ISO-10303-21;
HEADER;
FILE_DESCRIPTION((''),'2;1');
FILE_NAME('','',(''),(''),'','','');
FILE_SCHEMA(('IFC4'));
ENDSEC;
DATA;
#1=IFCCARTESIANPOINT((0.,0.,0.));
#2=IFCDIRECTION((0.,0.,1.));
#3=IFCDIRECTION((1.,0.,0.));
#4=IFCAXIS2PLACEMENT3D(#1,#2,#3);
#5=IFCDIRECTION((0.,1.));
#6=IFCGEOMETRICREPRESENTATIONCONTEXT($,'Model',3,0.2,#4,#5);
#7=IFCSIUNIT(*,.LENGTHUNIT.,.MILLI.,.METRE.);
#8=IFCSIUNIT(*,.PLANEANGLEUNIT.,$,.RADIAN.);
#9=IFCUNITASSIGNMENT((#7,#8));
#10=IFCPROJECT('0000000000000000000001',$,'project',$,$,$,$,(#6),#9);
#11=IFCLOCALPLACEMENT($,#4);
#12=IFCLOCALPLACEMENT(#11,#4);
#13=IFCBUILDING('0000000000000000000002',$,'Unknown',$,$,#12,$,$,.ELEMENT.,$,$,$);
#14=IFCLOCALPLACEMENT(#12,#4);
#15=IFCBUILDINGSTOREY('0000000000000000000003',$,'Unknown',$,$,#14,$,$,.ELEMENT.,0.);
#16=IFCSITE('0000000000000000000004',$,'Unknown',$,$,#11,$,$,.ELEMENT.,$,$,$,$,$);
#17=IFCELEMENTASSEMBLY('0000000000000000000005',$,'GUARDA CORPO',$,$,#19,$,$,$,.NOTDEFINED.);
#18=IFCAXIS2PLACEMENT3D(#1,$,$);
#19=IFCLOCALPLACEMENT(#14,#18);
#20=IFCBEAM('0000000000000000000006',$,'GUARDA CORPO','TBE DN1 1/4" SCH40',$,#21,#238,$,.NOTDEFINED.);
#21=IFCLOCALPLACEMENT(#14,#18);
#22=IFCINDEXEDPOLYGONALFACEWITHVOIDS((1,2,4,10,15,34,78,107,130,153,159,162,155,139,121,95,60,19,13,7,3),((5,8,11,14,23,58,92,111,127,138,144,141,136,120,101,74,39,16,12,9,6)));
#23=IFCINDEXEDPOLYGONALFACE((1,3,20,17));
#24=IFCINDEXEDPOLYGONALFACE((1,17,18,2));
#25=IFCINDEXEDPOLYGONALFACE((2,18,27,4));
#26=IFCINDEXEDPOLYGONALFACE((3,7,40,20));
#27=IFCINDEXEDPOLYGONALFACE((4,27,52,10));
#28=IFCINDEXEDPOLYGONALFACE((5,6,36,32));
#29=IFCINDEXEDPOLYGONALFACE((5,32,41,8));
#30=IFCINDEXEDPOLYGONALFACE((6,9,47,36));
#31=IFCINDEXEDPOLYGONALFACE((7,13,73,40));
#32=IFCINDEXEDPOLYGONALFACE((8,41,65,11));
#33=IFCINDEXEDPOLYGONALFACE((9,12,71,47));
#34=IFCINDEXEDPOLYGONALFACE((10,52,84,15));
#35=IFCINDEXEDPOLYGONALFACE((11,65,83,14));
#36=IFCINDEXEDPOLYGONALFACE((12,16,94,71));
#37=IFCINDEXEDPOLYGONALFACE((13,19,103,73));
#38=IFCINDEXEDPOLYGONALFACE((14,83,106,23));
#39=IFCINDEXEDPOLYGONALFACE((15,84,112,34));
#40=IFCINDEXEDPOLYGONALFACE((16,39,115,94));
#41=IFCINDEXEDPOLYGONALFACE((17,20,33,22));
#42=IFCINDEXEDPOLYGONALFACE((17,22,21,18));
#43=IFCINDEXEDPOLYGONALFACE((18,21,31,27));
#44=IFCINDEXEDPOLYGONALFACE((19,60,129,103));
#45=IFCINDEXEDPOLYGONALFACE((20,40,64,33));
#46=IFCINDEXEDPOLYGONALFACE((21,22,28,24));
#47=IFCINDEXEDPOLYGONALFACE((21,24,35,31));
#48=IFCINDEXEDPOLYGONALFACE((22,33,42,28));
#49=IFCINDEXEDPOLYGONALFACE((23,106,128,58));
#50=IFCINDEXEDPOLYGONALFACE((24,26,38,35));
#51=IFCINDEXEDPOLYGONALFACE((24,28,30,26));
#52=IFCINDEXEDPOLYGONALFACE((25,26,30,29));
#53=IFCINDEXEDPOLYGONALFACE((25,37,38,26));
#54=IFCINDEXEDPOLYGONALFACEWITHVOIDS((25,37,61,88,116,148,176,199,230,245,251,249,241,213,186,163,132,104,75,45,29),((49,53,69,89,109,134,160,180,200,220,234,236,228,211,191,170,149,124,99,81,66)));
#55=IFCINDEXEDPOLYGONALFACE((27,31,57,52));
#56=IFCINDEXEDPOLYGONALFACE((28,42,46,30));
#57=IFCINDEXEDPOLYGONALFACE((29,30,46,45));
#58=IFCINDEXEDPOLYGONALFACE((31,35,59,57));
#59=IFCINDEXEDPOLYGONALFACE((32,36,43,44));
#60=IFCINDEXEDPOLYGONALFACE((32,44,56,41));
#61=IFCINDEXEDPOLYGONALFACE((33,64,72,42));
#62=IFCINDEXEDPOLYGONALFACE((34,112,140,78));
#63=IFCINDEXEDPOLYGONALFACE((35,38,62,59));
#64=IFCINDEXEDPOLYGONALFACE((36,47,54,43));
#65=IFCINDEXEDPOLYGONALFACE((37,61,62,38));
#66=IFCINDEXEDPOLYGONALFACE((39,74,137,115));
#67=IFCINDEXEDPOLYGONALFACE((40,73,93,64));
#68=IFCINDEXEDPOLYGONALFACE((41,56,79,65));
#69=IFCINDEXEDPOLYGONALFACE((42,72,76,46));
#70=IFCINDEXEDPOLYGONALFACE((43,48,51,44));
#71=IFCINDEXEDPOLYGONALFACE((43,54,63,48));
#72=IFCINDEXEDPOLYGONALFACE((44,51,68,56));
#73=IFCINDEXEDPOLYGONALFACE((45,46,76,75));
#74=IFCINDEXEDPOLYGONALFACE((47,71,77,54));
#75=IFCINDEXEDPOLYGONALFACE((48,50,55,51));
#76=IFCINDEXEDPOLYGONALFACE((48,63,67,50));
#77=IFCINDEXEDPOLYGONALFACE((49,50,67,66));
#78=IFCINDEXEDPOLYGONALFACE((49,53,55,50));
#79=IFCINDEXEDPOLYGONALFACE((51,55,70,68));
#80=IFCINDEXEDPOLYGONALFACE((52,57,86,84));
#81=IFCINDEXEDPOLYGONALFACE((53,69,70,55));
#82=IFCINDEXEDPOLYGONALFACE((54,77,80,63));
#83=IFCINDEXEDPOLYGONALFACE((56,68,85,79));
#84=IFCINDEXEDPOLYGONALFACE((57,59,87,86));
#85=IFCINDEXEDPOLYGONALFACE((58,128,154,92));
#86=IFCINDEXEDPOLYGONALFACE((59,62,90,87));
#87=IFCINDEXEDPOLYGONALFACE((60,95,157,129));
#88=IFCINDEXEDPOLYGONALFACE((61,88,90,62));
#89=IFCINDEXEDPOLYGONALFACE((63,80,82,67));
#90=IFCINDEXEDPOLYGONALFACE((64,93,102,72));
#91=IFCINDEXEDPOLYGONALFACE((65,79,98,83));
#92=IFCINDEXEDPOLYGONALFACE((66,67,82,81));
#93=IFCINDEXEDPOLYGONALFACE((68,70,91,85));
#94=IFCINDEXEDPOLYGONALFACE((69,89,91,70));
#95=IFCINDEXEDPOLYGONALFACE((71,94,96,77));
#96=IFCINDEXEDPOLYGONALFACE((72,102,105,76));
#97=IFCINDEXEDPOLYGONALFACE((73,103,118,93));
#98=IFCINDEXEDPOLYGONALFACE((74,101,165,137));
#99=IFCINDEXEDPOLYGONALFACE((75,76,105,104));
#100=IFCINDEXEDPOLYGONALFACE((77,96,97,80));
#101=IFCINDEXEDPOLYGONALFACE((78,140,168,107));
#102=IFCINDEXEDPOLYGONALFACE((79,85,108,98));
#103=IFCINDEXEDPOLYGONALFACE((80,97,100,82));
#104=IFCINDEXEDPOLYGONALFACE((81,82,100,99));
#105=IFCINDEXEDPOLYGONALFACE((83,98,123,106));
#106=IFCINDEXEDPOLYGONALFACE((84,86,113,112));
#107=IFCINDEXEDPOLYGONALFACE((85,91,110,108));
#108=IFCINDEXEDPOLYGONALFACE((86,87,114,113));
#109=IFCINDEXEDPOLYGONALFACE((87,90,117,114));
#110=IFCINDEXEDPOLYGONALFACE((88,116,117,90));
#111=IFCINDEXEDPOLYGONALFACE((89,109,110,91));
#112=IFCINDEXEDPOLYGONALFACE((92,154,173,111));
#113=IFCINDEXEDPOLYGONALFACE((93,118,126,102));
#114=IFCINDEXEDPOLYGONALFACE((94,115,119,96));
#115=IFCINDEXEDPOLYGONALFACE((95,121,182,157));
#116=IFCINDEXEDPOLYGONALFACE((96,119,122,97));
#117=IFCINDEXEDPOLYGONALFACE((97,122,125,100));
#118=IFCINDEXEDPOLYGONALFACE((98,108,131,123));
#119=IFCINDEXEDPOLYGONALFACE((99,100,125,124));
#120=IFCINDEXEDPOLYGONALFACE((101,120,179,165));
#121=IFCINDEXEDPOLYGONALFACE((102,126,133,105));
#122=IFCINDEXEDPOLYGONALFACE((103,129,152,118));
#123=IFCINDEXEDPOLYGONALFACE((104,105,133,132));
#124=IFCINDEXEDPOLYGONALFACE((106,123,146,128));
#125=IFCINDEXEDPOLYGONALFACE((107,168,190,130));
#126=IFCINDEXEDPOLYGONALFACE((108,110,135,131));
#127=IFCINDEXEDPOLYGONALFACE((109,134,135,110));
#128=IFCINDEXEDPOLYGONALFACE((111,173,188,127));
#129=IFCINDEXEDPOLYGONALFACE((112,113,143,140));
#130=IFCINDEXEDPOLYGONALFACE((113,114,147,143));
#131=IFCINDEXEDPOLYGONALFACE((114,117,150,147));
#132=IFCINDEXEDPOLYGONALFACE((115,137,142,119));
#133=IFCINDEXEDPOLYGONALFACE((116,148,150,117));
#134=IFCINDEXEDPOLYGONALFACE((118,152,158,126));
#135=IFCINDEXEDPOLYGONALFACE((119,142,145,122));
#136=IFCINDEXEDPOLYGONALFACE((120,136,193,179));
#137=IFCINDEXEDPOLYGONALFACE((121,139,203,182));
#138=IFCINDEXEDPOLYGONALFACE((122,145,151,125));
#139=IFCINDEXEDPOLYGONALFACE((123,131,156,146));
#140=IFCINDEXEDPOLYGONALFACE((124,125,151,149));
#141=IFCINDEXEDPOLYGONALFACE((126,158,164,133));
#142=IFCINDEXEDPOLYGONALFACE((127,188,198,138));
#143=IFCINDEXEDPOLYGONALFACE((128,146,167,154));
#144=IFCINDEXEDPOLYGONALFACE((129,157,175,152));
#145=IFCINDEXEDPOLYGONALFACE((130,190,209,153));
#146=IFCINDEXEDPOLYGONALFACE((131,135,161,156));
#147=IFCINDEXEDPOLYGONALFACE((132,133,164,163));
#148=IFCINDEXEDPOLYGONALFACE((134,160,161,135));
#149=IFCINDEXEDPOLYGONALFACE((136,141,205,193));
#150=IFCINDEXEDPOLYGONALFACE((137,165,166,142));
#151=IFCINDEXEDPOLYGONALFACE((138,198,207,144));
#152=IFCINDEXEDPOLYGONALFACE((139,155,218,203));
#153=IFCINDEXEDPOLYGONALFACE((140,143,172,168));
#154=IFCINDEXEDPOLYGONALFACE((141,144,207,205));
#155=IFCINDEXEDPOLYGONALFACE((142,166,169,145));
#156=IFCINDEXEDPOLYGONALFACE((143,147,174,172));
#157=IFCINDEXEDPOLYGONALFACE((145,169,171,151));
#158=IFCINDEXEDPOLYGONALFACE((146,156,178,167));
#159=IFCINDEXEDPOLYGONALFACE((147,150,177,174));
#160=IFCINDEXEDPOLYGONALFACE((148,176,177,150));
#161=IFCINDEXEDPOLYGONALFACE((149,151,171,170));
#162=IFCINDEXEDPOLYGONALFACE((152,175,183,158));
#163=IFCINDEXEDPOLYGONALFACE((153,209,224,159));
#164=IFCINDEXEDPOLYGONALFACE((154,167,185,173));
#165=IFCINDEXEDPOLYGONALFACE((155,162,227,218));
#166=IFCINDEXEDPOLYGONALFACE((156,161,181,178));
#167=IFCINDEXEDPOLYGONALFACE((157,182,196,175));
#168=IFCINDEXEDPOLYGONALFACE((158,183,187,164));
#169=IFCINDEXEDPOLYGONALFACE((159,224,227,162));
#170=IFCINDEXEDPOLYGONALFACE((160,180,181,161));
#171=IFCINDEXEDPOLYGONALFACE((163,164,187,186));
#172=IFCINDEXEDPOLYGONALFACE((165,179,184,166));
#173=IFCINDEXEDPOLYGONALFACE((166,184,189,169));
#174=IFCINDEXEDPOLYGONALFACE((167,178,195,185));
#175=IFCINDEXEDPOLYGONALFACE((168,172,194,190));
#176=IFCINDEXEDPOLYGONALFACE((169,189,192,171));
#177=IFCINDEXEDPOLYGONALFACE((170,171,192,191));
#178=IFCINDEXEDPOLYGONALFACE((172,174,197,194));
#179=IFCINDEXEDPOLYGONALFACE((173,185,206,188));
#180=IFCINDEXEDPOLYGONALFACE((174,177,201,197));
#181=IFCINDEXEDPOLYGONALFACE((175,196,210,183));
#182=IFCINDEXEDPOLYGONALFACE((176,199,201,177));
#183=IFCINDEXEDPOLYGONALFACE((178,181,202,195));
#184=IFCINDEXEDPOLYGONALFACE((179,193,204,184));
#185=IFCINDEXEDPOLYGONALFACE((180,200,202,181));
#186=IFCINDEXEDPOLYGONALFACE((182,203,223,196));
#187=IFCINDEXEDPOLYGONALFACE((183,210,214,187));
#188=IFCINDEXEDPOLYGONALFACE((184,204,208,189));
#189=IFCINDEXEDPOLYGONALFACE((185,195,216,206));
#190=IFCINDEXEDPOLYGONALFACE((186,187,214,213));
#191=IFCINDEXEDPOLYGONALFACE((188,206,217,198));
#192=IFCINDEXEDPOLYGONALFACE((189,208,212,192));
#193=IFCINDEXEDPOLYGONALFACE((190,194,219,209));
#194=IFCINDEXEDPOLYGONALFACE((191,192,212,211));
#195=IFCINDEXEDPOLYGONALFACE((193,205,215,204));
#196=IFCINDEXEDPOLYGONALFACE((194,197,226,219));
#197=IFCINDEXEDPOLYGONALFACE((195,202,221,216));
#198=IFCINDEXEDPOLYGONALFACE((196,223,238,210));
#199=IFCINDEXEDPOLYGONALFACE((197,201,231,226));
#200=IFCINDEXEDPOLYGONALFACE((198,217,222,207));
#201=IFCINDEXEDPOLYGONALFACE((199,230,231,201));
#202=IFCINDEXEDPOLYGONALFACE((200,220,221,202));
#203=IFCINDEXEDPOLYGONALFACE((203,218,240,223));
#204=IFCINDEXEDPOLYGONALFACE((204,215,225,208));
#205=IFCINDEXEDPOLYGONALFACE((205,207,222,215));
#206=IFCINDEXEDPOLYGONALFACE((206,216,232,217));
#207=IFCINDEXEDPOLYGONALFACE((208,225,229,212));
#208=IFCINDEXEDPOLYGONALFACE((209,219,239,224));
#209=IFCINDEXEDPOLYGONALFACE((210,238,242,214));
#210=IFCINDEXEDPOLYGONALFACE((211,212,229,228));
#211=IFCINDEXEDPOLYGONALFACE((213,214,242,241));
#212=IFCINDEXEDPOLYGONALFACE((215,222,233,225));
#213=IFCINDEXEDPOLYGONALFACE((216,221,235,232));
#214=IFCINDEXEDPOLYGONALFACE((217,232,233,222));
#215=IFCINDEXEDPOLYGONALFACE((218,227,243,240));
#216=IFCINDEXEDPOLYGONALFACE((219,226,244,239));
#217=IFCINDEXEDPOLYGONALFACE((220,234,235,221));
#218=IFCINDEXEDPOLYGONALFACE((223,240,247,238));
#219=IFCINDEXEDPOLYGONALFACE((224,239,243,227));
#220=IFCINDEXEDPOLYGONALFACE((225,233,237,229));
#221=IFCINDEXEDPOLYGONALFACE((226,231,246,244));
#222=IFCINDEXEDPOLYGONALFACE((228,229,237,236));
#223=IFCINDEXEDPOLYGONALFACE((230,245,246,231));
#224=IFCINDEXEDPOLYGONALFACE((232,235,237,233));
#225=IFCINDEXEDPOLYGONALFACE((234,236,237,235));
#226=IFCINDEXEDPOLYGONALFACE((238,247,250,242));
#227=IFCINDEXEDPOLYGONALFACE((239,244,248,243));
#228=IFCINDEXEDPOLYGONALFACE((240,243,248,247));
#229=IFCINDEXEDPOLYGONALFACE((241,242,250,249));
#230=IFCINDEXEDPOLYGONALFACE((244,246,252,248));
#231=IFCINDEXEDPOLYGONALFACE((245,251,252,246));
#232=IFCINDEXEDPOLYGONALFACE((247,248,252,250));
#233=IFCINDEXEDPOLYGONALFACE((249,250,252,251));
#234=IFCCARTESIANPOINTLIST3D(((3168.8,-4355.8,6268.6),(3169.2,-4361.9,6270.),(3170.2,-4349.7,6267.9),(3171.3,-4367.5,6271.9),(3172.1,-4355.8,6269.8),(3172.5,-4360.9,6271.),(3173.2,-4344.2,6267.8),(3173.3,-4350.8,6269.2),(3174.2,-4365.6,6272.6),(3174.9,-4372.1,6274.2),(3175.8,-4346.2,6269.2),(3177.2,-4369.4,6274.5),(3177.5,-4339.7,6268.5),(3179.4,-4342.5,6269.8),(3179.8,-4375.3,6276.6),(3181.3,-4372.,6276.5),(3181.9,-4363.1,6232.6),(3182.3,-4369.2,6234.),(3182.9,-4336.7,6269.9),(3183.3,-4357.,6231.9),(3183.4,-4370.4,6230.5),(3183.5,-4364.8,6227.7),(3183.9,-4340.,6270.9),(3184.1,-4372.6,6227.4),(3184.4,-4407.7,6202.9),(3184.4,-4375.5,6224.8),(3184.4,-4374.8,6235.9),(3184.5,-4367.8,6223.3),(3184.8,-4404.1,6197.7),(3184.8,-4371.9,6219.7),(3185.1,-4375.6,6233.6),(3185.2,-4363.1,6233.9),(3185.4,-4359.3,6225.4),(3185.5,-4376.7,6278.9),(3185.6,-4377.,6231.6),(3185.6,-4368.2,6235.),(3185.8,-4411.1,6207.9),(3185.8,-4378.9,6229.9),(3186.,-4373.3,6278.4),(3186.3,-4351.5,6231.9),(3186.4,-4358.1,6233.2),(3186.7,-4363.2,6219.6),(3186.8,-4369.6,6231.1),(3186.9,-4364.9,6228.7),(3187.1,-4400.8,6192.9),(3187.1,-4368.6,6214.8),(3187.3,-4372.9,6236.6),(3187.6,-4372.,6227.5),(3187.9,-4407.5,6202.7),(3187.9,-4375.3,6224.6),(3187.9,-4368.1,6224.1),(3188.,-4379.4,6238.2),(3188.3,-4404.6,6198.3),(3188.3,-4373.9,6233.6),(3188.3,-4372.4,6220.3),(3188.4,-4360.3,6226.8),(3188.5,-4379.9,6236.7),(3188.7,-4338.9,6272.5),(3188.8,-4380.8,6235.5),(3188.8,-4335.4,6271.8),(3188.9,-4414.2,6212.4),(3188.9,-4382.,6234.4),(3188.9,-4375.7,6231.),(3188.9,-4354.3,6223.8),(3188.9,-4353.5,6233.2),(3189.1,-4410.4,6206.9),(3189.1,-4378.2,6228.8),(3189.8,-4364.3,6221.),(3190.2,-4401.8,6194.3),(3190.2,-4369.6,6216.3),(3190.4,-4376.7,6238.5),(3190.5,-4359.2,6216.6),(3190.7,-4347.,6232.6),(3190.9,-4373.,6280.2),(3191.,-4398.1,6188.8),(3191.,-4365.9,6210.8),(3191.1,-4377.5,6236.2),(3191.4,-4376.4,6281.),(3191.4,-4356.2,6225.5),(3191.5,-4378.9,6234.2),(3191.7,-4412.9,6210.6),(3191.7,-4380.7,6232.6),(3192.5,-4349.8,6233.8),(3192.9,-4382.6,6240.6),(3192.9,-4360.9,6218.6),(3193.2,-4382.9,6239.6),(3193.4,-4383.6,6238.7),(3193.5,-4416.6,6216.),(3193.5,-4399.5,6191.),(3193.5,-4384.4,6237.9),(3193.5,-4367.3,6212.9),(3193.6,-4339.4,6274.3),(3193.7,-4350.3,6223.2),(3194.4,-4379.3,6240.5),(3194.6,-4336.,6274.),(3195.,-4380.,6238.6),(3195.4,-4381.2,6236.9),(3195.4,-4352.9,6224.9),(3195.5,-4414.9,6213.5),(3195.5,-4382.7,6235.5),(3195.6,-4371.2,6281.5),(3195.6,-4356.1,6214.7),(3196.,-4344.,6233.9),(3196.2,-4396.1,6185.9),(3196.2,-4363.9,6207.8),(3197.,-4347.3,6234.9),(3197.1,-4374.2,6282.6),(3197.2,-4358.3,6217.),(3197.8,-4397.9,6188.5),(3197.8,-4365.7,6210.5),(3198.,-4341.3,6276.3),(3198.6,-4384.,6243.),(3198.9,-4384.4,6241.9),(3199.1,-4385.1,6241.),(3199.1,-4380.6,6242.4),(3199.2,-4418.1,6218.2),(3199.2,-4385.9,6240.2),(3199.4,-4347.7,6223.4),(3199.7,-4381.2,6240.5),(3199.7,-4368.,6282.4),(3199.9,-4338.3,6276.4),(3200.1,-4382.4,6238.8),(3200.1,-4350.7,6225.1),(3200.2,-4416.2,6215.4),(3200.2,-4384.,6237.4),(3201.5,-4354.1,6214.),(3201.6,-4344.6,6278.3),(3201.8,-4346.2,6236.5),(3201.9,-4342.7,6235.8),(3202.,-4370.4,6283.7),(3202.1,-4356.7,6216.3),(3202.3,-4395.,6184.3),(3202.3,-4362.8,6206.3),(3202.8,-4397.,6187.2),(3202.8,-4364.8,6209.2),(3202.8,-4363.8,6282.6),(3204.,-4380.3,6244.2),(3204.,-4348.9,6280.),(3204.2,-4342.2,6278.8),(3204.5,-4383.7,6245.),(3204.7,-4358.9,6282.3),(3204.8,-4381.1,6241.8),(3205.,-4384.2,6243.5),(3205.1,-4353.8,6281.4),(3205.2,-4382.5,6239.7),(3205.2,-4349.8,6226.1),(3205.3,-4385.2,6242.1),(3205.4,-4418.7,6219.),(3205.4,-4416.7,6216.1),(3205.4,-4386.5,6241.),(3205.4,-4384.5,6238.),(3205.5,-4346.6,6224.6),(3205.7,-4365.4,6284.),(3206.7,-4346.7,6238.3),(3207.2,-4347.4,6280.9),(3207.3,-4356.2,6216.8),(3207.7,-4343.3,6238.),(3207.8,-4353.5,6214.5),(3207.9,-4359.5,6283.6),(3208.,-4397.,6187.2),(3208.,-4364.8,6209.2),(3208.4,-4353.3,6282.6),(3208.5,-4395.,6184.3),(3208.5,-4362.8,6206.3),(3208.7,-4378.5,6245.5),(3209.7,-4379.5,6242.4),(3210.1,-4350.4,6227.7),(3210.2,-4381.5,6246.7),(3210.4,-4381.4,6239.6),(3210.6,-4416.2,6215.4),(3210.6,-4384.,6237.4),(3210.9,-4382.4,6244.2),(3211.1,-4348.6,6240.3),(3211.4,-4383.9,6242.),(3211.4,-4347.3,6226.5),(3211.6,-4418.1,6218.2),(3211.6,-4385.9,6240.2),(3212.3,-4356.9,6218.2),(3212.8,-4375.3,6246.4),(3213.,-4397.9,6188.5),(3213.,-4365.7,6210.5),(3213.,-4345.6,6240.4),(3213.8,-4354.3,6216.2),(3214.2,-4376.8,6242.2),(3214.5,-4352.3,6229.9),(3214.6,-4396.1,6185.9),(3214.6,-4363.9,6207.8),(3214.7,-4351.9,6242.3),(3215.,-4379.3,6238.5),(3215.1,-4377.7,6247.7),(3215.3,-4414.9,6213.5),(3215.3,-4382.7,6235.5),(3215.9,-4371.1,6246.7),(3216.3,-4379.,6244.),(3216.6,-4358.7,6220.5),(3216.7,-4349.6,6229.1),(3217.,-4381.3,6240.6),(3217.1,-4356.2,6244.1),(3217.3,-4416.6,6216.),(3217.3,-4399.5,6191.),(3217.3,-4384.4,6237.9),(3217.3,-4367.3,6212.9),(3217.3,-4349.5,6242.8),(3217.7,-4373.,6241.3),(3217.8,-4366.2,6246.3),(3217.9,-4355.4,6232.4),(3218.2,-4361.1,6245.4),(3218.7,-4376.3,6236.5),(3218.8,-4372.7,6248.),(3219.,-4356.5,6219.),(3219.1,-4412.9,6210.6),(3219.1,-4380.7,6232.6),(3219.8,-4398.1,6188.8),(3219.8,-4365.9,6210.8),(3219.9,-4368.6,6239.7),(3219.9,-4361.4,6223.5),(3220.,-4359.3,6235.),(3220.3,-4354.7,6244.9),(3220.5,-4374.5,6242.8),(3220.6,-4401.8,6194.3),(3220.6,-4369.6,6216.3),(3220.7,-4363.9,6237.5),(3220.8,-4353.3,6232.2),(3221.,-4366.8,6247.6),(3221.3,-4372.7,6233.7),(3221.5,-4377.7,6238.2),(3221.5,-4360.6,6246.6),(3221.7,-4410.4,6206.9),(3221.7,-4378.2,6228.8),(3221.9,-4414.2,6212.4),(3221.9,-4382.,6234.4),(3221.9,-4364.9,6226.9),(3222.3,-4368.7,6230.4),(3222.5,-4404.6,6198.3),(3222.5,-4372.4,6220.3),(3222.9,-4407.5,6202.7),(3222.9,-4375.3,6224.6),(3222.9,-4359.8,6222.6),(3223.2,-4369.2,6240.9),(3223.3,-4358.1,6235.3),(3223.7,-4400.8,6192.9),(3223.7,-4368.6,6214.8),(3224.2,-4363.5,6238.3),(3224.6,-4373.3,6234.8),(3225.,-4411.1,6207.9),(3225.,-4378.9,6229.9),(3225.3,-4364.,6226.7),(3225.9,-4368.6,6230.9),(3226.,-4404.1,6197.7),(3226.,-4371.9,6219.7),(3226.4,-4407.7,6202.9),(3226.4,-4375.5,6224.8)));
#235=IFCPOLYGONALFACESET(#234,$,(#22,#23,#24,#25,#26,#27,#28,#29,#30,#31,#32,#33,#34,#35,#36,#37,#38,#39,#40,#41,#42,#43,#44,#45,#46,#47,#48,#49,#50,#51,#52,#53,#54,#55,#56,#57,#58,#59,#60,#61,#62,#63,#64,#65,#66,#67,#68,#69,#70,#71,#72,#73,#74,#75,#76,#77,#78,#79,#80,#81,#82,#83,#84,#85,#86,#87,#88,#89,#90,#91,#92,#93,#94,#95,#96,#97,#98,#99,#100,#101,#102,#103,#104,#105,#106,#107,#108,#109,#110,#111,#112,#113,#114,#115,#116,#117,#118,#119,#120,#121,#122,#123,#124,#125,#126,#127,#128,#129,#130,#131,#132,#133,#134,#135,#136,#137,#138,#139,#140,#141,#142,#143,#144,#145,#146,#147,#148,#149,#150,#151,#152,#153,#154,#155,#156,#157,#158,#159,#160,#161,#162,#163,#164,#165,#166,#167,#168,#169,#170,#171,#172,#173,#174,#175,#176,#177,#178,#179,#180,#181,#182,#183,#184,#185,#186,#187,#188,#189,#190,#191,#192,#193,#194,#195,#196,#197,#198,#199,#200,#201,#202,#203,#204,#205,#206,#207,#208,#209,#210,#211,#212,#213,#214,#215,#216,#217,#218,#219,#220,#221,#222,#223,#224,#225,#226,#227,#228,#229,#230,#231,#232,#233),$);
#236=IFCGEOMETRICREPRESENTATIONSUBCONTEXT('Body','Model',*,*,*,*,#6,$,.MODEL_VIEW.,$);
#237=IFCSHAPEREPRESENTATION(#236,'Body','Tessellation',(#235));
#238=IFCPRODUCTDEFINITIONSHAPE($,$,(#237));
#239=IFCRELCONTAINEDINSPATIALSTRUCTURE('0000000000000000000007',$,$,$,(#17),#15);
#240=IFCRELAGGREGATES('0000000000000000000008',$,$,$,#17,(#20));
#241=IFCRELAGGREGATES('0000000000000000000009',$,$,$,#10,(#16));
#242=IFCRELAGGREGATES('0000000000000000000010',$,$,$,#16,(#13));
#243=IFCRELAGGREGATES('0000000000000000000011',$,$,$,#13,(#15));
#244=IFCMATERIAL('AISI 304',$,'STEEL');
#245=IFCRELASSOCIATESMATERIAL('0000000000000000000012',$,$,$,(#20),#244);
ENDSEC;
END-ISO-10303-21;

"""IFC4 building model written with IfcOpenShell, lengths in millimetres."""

from ifc_helpers import new_model, entity, si_unit, direction, frame, origin_with_axes, place, context, subcontext, project, spatial, material, element, aggregate, save


model = new_model("IFC4")

# Units and contexts
model_context = context("Model", 3, precision=0.2, world=origin_with_axes(), true_north=direction((0.0, 1.0)))
body_context = subcontext(model_context, "Body", "Model", "MODEL_VIEW")
ifc_project = project(units=[si_unit("LENGTHUNIT", "METRE", prefix="MILLI"), si_unit("PLANEANGLEUNIT", "RADIAN")], contexts=[model_context])

# Site, building, storey
site_placement = place(None, origin_with_axes())
site = spatial("IfcSite", under=ifc_project, at=site_placement, Name="Unknown", CompositionType="ELEMENT")
building_placement = place(site_placement, origin_with_axes())
building = spatial("IfcBuilding", under=site, at=building_placement, Name="Unknown", CompositionType="ELEMENT")
storey_placement = place(building_placement, origin_with_axes())
storey = spatial("IfcBuildingStorey", under=building, at=storey_placement, Name="Unknown", CompositionType="ELEMENT", Elevation=0.0)

# Element assembly, beam
assembly_1_placement = place(storey_placement, frame((2908.2, -5645.6, 3955.0), z_axis=(0.000512, -1.0, -0.000003), x_axis=(0.000003, -0.000003, 1.0)))
assembly_1 = element("IfcElementAssembly", 1, at=assembly_1_placement, inside=storey, Name="GUARDA CORPO", PredefinedType="NOTDEFINED")
ifc_material_1 = material(Name="AISI 304", Category="STEEL")
beam_1_placement = place(assembly_1_placement, frame((2246.6, -297.9, -1238.7), z_axis=(0.826215, 0.000295, 0.563355), x_axis=(0.563355, -0.000419, -0.826215)))
beam_1 = element("IfcBeam", 2, at=beam_1_placement, material=ifc_material_1, Name="GUARDA CORPO", Description="TBE DN1 1/4\" SCH40", PredefinedType="NOTDEFINED", context=body_context, shape_type="SolidModel", body=[
    entity("IfcSweptDiskSolid", entity("IfcIndexedPolyCurve", entity("IfcCartesianPointList3D", [[0.0, 0.0, 0.0], [39.0, 0.0, 0.0], [49.1, 1.0, 1.9], [57.4, 3.7, 7.2], [83.7, 16.8, 32.9]]), [entity("IfcLineIndex", [1, 2]), entity("IfcArcIndex", [2, 3, 4]), entity("IfcLineIndex", [4, 5])]), 21.1, 17.5),
])

aggregate(assembly_1, [beam_1])

save(model, "model.ifc")
